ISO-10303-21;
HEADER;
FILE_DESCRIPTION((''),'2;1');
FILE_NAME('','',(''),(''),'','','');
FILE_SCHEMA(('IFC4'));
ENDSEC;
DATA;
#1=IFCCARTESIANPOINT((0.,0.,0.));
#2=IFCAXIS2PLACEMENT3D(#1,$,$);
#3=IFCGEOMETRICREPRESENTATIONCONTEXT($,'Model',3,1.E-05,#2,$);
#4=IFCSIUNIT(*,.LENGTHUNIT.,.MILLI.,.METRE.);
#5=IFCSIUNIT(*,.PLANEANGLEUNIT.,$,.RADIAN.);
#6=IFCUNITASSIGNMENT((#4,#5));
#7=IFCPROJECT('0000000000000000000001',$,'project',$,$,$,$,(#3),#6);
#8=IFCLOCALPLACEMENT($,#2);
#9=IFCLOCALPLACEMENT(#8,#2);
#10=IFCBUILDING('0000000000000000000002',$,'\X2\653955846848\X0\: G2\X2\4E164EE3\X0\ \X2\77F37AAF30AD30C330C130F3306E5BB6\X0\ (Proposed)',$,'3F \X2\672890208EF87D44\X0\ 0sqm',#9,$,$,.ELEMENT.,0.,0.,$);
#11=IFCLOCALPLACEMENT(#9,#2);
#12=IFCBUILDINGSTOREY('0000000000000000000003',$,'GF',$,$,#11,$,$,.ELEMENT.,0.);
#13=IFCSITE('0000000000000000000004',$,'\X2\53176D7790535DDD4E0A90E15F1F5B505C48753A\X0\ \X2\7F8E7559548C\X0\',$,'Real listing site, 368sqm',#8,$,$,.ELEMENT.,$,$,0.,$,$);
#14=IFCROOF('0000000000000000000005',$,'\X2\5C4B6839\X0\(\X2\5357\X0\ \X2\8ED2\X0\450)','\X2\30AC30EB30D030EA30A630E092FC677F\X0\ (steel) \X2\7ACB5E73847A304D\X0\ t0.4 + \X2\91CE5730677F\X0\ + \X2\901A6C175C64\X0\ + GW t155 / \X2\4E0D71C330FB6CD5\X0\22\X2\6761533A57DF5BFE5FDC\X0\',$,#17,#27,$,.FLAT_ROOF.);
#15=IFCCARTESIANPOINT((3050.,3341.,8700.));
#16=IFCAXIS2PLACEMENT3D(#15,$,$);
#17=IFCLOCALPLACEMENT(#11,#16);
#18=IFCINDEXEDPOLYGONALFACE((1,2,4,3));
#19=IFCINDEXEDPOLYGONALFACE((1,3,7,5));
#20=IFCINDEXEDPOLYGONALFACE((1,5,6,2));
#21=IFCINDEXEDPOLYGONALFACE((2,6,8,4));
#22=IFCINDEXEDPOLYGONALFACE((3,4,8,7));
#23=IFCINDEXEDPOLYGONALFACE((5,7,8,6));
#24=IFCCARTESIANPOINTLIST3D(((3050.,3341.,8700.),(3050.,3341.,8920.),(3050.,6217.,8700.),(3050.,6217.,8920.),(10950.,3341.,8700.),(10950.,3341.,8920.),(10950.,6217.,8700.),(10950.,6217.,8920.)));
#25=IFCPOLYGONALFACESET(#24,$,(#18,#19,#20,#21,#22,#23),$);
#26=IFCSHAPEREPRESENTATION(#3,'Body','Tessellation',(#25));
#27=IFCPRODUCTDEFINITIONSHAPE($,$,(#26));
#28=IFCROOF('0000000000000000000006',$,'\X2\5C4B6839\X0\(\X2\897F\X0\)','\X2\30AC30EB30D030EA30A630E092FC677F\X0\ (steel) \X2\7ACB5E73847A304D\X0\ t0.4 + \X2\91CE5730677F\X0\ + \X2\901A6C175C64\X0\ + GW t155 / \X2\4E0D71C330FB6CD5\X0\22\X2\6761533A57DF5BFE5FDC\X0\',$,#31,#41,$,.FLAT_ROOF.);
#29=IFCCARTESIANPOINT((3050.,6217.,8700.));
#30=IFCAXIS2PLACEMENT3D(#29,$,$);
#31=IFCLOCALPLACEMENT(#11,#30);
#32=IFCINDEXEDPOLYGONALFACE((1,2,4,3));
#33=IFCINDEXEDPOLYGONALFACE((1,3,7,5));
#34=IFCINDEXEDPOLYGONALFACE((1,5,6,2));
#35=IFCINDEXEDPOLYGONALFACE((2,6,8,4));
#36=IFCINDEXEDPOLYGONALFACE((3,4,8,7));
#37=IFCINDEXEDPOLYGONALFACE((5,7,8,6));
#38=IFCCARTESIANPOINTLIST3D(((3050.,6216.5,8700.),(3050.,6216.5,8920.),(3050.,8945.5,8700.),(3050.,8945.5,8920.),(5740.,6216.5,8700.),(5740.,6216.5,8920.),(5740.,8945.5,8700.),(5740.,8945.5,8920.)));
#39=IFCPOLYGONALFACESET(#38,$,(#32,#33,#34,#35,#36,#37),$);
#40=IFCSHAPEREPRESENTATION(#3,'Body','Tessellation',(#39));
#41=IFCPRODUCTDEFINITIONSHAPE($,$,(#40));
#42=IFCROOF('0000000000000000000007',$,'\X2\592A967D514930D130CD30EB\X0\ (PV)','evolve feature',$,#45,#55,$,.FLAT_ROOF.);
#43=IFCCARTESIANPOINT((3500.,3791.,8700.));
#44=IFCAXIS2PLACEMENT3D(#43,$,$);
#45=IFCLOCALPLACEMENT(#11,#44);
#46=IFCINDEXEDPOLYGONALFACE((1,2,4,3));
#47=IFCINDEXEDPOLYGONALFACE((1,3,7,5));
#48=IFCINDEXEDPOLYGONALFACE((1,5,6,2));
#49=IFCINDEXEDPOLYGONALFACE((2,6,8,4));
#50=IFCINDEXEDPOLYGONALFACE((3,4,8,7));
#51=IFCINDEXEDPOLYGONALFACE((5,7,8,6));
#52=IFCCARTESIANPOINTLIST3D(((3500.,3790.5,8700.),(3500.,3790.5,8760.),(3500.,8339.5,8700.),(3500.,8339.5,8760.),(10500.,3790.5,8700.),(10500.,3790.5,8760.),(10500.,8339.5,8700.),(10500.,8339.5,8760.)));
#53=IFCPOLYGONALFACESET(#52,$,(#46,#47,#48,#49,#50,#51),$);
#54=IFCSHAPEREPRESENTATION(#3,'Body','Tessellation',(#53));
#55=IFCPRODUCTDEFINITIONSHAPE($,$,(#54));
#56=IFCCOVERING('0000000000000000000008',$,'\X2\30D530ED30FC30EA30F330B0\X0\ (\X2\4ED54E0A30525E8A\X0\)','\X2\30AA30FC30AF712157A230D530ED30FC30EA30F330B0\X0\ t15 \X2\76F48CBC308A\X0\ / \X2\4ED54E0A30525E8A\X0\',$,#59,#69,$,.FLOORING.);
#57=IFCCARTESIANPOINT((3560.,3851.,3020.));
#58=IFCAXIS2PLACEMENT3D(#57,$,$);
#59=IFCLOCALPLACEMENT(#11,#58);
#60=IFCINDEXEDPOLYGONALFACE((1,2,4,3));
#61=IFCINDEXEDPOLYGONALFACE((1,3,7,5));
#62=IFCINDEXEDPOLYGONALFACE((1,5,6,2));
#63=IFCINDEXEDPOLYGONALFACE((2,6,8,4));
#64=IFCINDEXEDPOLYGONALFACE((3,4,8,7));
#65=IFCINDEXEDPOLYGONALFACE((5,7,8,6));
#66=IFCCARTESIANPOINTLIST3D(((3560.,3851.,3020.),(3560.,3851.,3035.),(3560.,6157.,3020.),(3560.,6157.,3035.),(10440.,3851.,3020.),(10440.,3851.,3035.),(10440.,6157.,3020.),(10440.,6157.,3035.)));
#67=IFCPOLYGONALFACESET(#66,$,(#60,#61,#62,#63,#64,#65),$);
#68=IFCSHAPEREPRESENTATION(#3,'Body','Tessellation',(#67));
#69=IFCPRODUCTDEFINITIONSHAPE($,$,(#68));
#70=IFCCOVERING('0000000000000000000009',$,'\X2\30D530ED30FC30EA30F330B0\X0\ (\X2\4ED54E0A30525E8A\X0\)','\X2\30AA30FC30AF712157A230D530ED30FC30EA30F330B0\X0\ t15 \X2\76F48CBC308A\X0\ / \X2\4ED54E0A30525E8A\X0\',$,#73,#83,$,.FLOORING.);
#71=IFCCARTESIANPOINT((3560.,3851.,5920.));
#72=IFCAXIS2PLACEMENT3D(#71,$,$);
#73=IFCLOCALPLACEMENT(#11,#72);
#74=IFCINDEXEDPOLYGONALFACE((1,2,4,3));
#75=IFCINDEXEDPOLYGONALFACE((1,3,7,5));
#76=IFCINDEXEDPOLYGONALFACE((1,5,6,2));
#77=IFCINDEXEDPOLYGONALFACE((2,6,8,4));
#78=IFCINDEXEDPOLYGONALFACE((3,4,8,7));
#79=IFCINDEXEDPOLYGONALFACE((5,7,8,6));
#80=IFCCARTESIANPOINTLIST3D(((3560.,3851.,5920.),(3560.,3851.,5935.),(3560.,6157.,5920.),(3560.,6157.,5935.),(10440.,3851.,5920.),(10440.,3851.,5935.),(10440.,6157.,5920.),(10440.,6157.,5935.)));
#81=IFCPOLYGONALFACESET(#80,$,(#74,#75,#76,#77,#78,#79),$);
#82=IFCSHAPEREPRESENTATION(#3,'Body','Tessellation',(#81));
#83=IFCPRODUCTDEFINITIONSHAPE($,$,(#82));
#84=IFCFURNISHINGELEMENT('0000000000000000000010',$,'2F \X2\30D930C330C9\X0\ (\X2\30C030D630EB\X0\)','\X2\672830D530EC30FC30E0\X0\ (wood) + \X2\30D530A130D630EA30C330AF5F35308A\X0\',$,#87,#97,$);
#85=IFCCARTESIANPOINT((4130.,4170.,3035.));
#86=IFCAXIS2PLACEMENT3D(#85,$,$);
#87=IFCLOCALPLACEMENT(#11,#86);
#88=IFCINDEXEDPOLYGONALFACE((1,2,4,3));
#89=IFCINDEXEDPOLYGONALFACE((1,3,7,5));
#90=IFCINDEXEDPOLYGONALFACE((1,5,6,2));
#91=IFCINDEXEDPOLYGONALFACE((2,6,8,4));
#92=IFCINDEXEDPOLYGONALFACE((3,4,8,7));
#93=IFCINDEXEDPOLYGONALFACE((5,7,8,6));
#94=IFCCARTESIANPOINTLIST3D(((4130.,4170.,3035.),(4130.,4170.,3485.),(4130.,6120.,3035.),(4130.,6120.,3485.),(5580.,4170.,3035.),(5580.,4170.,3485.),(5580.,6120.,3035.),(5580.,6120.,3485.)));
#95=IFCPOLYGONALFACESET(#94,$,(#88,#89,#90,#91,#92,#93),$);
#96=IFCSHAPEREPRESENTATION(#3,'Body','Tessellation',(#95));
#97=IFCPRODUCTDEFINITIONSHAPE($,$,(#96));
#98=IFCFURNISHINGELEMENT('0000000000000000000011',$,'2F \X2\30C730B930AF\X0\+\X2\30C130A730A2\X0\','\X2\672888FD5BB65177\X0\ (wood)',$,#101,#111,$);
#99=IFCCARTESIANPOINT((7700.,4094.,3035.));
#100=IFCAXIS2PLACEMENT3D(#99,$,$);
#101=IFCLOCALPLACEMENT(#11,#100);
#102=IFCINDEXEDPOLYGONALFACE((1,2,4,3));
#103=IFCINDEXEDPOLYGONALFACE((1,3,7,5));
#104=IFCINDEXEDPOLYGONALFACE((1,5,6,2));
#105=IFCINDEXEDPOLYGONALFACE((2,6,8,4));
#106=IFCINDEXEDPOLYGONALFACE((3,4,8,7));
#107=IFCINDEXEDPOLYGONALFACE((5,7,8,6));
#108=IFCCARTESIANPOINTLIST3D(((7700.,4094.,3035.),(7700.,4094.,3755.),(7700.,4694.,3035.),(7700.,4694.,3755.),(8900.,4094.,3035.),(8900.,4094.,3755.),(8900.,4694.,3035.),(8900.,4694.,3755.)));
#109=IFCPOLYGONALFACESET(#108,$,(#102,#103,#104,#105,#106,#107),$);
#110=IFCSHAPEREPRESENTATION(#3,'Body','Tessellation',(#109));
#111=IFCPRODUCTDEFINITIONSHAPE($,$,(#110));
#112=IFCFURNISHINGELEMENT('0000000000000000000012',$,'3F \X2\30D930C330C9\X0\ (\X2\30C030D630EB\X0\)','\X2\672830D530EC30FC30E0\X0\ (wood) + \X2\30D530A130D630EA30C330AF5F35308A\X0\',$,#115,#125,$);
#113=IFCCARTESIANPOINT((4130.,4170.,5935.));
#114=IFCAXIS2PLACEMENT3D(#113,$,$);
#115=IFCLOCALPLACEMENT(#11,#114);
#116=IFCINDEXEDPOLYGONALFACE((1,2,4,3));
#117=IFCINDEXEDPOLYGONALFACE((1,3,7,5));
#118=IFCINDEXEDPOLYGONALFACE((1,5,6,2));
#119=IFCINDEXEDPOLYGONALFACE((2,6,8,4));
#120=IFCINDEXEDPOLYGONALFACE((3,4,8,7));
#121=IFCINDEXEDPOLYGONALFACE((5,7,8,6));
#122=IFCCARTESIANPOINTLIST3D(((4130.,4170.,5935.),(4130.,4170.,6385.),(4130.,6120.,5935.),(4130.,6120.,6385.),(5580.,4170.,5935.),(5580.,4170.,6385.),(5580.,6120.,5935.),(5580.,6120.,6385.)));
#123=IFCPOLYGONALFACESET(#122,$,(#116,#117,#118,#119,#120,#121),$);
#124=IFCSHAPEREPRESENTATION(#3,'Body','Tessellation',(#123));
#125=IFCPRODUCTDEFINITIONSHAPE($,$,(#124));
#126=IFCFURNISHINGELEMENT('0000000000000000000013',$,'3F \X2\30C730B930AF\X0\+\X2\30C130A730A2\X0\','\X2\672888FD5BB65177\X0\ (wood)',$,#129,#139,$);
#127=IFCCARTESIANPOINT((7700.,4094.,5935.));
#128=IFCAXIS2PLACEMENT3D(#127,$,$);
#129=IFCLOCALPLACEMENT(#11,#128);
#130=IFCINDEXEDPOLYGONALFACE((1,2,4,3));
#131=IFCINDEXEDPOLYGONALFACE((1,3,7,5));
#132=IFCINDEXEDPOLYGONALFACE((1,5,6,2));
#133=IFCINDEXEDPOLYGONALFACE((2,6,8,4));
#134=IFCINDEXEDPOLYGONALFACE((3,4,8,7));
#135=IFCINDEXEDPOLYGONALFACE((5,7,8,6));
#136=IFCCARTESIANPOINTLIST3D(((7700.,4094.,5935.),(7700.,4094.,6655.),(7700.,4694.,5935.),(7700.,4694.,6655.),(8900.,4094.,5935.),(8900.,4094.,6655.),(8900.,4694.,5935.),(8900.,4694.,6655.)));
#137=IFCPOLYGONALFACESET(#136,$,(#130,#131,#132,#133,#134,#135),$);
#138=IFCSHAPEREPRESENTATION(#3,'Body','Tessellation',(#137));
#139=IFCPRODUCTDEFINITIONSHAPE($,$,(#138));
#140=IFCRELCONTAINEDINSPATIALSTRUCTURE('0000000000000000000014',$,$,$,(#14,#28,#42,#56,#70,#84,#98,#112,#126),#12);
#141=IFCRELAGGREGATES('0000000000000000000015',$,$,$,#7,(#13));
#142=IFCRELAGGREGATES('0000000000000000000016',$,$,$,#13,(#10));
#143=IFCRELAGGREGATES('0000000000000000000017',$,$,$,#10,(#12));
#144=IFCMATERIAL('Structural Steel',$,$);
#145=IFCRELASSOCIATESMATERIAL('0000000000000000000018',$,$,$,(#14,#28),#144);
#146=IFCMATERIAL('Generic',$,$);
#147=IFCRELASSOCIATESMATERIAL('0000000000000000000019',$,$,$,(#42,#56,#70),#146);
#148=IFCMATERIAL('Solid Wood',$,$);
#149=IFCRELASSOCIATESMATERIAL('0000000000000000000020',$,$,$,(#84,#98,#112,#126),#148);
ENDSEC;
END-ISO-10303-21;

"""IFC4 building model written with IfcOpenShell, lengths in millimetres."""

from ifc_helpers import new_model, si_unit, frame, frame_2d, origin, place, context, project, spatial, rectangle, extrude, material, element, save


model = new_model("IFC4")

# Units and contexts
model_context = context("Model", 3, precision=1e-05, world=origin())
ifc_project = project(units=[si_unit("LENGTHUNIT", "METRE", prefix="MILLI"), si_unit("PLANEANGLEUNIT", "RADIAN")], contexts=[model_context])

# Site, building, storey
site_placement = place(None, origin())
site = spatial("IfcSite", under=ifc_project, at=site_placement, Name="北海道川上郡弟子屈町 美留和", ObjectType="Real listing site, 368sqm", CompositionType="ELEMENT", RefElevation=0.0)
building_placement = place(site_placement, origin())
building = spatial("IfcBuilding", under=site, at=building_placement, Name="改善案: G2世代 石窯キッチンの家 (Proposed)", ObjectType="3F 木造軸組 0sqm", CompositionType="ELEMENT", ElevationOfRefHeight=0.0, ElevationOfTerrain=0.0)
storey_placement = place(building_placement, origin())
storey = spatial("IfcBuildingStorey", under=building, at=storey_placement, Name="GF", CompositionType="ELEMENT", Elevation=0.0)

# Shared definitions
ifc_material_1 = material(Name="Solid Wood")

# Roofs
ifc_material_2 = material(Name="Structural Steel")
roof_1_placement = place(storey_placement, frame((3050.0, 3341.0, 8700.0)))
element("IfcRoof", 1, at=roof_1_placement, inside=storey, material=ifc_material_2, Name="屋根(南 軒450)", Description="ガルバリウム鋼板 (steel) 立平葺き t0.4 + 野地板 + 通気層 + GW t155 / 不燃・法22条区域対応", PredefinedType="FLAT_ROOF", context=model_context, shape_type="SweptSolid", body=[
    extrude(rectangle(XDim=7900.0, YDim=2876.0, at=frame_2d((3950.0, 1438.0))), frame((3050.0, 3341.0, 8700.0)), (0.0, 0.0, 1.0), 220.0),
])
roof_2_placement = place(storey_placement, frame((3050.0, 6217.0, 8700.0)))
element("IfcRoof", 2, at=roof_2_placement, inside=storey, material=ifc_material_2, Name="屋根(西)", Description="ガルバリウム鋼板 (steel) 立平葺き t0.4 + 野地板 + 通気層 + GW t155 / 不燃・法22条区域対応", PredefinedType="FLAT_ROOF", context=model_context, shape_type="SweptSolid", body=[
    extrude(rectangle(XDim=2690.0, YDim=2729.0, at=frame_2d((1345.0, 1364.0))), frame((3050.0, 6217.0, 8700.0)), (0.0, 0.0, 1.0), 220.0),
])
ifc_material_3 = material(Name="Generic")
roof_3_placement = place(storey_placement, frame((3500.0, 3791.0, 8700.0)))
element("IfcRoof", 3, at=roof_3_placement, inside=storey, material=ifc_material_3, Name="太陽光パネル (PV)", Description="evolve feature", PredefinedType="FLAT_ROOF", context=model_context, shape_type="SweptSolid", body=[
    extrude(rectangle(XDim=7000.0, YDim=4549.0, at=frame_2d((3500.0, 2274.0))), frame((3500.0, 3791.0, 8700.0)), (0.0, 0.0, 1.0), 60.0),
])

# Coverings
covering_1_placement = place(storey_placement, frame((3560.0, 3851.0, 3020.0)))
element("IfcCovering", 4, at=covering_1_placement, inside=storey, material=ifc_material_3, Name="フローリング (仕上げ床)", Description="オーク無垢フローリング t15 直貼り / 仕上げ床", PredefinedType="FLOORING", context=model_context, shape_type="SweptSolid", body=[
    extrude(rectangle(XDim=6880.0, YDim=2306.0, at=frame_2d((3440.0, 1153.0))), frame((3560.0, 3851.0, 3020.0)), (0.0, 0.0, 1.0), 15.0),
])
covering_2_placement = place(storey_placement, frame((3560.0, 3851.0, 5920.0)))
element("IfcCovering", 5, at=covering_2_placement, inside=storey, material=ifc_material_3, Name="フローリング (仕上げ床)", Description="オーク無垢フローリング t15 直貼り / 仕上げ床", PredefinedType="FLOORING", context=model_context, shape_type="SweptSolid", body=[
    extrude(rectangle(XDim=6880.0, YDim=2306.0, at=frame_2d((3440.0, 1153.0))), frame((3560.0, 3851.0, 5920.0)), (0.0, 0.0, 1.0), 15.0),
])

# Furnishing elements
furnishing_1_placement = place(storey_placement, frame((4130.0, 4170.0, 3035.0)))
element("IfcFurnishingElement", 6, at=furnishing_1_placement, inside=storey, material=ifc_material_1, Name="2F ベッド (ダブル)", Description="木フレーム (wood) + ファブリック張り", context=model_context, shape_type="SweptSolid", body=[
    extrude(rectangle(XDim=1450.0, YDim=1950.0, at=frame_2d((725.0, 975.0))), frame((4130.0, 4170.0, 3035.0)), (0.0, 0.0, 1.0), 450.0),
])
furnishing_2_placement = place(storey_placement, frame((7700.0, 4094.0, 3035.0)))
element("IfcFurnishingElement", 7, at=furnishing_2_placement, inside=storey, material=ifc_material_1, Name="2F デスク+チェア", Description="木製家具 (wood)", context=model_context, shape_type="SweptSolid", body=[
    extrude(rectangle(XDim=1200.0, YDim=600.0, at=frame_2d((600.0, 300.0))), frame((7700.0, 4094.0, 3035.0)), (0.0, 0.0, 1.0), 720.0),
])
furnishing_3_placement = place(storey_placement, frame((4130.0, 4170.0, 5935.0)))
element("IfcFurnishingElement", 8, at=furnishing_3_placement, inside=storey, material=ifc_material_1, Name="3F ベッド (ダブル)", Description="木フレーム (wood) + ファブリック張り", context=model_context, shape_type="SweptSolid", body=[
    extrude(rectangle(XDim=1450.0, YDim=1950.0, at=frame_2d((725.0, 975.0))), frame((4130.0, 4170.0, 5935.0)), (0.0, 0.0, 1.0), 450.0),
])
furnishing_4_placement = place(storey_placement, frame((7700.0, 4094.0, 5935.0)))
element("IfcFurnishingElement", 9, at=furnishing_4_placement, inside=storey, material=ifc_material_1, Name="3F デスク+チェア", Description="木製家具 (wood)", context=model_context, shape_type="SweptSolid", body=[
    extrude(rectangle(XDim=1200.0, YDim=600.0, at=frame_2d((600.0, 300.0))), frame((7700.0, 4094.0, 5935.0)), (0.0, 0.0, 1.0), 720.0),
])

save(model, "model.ifc")
